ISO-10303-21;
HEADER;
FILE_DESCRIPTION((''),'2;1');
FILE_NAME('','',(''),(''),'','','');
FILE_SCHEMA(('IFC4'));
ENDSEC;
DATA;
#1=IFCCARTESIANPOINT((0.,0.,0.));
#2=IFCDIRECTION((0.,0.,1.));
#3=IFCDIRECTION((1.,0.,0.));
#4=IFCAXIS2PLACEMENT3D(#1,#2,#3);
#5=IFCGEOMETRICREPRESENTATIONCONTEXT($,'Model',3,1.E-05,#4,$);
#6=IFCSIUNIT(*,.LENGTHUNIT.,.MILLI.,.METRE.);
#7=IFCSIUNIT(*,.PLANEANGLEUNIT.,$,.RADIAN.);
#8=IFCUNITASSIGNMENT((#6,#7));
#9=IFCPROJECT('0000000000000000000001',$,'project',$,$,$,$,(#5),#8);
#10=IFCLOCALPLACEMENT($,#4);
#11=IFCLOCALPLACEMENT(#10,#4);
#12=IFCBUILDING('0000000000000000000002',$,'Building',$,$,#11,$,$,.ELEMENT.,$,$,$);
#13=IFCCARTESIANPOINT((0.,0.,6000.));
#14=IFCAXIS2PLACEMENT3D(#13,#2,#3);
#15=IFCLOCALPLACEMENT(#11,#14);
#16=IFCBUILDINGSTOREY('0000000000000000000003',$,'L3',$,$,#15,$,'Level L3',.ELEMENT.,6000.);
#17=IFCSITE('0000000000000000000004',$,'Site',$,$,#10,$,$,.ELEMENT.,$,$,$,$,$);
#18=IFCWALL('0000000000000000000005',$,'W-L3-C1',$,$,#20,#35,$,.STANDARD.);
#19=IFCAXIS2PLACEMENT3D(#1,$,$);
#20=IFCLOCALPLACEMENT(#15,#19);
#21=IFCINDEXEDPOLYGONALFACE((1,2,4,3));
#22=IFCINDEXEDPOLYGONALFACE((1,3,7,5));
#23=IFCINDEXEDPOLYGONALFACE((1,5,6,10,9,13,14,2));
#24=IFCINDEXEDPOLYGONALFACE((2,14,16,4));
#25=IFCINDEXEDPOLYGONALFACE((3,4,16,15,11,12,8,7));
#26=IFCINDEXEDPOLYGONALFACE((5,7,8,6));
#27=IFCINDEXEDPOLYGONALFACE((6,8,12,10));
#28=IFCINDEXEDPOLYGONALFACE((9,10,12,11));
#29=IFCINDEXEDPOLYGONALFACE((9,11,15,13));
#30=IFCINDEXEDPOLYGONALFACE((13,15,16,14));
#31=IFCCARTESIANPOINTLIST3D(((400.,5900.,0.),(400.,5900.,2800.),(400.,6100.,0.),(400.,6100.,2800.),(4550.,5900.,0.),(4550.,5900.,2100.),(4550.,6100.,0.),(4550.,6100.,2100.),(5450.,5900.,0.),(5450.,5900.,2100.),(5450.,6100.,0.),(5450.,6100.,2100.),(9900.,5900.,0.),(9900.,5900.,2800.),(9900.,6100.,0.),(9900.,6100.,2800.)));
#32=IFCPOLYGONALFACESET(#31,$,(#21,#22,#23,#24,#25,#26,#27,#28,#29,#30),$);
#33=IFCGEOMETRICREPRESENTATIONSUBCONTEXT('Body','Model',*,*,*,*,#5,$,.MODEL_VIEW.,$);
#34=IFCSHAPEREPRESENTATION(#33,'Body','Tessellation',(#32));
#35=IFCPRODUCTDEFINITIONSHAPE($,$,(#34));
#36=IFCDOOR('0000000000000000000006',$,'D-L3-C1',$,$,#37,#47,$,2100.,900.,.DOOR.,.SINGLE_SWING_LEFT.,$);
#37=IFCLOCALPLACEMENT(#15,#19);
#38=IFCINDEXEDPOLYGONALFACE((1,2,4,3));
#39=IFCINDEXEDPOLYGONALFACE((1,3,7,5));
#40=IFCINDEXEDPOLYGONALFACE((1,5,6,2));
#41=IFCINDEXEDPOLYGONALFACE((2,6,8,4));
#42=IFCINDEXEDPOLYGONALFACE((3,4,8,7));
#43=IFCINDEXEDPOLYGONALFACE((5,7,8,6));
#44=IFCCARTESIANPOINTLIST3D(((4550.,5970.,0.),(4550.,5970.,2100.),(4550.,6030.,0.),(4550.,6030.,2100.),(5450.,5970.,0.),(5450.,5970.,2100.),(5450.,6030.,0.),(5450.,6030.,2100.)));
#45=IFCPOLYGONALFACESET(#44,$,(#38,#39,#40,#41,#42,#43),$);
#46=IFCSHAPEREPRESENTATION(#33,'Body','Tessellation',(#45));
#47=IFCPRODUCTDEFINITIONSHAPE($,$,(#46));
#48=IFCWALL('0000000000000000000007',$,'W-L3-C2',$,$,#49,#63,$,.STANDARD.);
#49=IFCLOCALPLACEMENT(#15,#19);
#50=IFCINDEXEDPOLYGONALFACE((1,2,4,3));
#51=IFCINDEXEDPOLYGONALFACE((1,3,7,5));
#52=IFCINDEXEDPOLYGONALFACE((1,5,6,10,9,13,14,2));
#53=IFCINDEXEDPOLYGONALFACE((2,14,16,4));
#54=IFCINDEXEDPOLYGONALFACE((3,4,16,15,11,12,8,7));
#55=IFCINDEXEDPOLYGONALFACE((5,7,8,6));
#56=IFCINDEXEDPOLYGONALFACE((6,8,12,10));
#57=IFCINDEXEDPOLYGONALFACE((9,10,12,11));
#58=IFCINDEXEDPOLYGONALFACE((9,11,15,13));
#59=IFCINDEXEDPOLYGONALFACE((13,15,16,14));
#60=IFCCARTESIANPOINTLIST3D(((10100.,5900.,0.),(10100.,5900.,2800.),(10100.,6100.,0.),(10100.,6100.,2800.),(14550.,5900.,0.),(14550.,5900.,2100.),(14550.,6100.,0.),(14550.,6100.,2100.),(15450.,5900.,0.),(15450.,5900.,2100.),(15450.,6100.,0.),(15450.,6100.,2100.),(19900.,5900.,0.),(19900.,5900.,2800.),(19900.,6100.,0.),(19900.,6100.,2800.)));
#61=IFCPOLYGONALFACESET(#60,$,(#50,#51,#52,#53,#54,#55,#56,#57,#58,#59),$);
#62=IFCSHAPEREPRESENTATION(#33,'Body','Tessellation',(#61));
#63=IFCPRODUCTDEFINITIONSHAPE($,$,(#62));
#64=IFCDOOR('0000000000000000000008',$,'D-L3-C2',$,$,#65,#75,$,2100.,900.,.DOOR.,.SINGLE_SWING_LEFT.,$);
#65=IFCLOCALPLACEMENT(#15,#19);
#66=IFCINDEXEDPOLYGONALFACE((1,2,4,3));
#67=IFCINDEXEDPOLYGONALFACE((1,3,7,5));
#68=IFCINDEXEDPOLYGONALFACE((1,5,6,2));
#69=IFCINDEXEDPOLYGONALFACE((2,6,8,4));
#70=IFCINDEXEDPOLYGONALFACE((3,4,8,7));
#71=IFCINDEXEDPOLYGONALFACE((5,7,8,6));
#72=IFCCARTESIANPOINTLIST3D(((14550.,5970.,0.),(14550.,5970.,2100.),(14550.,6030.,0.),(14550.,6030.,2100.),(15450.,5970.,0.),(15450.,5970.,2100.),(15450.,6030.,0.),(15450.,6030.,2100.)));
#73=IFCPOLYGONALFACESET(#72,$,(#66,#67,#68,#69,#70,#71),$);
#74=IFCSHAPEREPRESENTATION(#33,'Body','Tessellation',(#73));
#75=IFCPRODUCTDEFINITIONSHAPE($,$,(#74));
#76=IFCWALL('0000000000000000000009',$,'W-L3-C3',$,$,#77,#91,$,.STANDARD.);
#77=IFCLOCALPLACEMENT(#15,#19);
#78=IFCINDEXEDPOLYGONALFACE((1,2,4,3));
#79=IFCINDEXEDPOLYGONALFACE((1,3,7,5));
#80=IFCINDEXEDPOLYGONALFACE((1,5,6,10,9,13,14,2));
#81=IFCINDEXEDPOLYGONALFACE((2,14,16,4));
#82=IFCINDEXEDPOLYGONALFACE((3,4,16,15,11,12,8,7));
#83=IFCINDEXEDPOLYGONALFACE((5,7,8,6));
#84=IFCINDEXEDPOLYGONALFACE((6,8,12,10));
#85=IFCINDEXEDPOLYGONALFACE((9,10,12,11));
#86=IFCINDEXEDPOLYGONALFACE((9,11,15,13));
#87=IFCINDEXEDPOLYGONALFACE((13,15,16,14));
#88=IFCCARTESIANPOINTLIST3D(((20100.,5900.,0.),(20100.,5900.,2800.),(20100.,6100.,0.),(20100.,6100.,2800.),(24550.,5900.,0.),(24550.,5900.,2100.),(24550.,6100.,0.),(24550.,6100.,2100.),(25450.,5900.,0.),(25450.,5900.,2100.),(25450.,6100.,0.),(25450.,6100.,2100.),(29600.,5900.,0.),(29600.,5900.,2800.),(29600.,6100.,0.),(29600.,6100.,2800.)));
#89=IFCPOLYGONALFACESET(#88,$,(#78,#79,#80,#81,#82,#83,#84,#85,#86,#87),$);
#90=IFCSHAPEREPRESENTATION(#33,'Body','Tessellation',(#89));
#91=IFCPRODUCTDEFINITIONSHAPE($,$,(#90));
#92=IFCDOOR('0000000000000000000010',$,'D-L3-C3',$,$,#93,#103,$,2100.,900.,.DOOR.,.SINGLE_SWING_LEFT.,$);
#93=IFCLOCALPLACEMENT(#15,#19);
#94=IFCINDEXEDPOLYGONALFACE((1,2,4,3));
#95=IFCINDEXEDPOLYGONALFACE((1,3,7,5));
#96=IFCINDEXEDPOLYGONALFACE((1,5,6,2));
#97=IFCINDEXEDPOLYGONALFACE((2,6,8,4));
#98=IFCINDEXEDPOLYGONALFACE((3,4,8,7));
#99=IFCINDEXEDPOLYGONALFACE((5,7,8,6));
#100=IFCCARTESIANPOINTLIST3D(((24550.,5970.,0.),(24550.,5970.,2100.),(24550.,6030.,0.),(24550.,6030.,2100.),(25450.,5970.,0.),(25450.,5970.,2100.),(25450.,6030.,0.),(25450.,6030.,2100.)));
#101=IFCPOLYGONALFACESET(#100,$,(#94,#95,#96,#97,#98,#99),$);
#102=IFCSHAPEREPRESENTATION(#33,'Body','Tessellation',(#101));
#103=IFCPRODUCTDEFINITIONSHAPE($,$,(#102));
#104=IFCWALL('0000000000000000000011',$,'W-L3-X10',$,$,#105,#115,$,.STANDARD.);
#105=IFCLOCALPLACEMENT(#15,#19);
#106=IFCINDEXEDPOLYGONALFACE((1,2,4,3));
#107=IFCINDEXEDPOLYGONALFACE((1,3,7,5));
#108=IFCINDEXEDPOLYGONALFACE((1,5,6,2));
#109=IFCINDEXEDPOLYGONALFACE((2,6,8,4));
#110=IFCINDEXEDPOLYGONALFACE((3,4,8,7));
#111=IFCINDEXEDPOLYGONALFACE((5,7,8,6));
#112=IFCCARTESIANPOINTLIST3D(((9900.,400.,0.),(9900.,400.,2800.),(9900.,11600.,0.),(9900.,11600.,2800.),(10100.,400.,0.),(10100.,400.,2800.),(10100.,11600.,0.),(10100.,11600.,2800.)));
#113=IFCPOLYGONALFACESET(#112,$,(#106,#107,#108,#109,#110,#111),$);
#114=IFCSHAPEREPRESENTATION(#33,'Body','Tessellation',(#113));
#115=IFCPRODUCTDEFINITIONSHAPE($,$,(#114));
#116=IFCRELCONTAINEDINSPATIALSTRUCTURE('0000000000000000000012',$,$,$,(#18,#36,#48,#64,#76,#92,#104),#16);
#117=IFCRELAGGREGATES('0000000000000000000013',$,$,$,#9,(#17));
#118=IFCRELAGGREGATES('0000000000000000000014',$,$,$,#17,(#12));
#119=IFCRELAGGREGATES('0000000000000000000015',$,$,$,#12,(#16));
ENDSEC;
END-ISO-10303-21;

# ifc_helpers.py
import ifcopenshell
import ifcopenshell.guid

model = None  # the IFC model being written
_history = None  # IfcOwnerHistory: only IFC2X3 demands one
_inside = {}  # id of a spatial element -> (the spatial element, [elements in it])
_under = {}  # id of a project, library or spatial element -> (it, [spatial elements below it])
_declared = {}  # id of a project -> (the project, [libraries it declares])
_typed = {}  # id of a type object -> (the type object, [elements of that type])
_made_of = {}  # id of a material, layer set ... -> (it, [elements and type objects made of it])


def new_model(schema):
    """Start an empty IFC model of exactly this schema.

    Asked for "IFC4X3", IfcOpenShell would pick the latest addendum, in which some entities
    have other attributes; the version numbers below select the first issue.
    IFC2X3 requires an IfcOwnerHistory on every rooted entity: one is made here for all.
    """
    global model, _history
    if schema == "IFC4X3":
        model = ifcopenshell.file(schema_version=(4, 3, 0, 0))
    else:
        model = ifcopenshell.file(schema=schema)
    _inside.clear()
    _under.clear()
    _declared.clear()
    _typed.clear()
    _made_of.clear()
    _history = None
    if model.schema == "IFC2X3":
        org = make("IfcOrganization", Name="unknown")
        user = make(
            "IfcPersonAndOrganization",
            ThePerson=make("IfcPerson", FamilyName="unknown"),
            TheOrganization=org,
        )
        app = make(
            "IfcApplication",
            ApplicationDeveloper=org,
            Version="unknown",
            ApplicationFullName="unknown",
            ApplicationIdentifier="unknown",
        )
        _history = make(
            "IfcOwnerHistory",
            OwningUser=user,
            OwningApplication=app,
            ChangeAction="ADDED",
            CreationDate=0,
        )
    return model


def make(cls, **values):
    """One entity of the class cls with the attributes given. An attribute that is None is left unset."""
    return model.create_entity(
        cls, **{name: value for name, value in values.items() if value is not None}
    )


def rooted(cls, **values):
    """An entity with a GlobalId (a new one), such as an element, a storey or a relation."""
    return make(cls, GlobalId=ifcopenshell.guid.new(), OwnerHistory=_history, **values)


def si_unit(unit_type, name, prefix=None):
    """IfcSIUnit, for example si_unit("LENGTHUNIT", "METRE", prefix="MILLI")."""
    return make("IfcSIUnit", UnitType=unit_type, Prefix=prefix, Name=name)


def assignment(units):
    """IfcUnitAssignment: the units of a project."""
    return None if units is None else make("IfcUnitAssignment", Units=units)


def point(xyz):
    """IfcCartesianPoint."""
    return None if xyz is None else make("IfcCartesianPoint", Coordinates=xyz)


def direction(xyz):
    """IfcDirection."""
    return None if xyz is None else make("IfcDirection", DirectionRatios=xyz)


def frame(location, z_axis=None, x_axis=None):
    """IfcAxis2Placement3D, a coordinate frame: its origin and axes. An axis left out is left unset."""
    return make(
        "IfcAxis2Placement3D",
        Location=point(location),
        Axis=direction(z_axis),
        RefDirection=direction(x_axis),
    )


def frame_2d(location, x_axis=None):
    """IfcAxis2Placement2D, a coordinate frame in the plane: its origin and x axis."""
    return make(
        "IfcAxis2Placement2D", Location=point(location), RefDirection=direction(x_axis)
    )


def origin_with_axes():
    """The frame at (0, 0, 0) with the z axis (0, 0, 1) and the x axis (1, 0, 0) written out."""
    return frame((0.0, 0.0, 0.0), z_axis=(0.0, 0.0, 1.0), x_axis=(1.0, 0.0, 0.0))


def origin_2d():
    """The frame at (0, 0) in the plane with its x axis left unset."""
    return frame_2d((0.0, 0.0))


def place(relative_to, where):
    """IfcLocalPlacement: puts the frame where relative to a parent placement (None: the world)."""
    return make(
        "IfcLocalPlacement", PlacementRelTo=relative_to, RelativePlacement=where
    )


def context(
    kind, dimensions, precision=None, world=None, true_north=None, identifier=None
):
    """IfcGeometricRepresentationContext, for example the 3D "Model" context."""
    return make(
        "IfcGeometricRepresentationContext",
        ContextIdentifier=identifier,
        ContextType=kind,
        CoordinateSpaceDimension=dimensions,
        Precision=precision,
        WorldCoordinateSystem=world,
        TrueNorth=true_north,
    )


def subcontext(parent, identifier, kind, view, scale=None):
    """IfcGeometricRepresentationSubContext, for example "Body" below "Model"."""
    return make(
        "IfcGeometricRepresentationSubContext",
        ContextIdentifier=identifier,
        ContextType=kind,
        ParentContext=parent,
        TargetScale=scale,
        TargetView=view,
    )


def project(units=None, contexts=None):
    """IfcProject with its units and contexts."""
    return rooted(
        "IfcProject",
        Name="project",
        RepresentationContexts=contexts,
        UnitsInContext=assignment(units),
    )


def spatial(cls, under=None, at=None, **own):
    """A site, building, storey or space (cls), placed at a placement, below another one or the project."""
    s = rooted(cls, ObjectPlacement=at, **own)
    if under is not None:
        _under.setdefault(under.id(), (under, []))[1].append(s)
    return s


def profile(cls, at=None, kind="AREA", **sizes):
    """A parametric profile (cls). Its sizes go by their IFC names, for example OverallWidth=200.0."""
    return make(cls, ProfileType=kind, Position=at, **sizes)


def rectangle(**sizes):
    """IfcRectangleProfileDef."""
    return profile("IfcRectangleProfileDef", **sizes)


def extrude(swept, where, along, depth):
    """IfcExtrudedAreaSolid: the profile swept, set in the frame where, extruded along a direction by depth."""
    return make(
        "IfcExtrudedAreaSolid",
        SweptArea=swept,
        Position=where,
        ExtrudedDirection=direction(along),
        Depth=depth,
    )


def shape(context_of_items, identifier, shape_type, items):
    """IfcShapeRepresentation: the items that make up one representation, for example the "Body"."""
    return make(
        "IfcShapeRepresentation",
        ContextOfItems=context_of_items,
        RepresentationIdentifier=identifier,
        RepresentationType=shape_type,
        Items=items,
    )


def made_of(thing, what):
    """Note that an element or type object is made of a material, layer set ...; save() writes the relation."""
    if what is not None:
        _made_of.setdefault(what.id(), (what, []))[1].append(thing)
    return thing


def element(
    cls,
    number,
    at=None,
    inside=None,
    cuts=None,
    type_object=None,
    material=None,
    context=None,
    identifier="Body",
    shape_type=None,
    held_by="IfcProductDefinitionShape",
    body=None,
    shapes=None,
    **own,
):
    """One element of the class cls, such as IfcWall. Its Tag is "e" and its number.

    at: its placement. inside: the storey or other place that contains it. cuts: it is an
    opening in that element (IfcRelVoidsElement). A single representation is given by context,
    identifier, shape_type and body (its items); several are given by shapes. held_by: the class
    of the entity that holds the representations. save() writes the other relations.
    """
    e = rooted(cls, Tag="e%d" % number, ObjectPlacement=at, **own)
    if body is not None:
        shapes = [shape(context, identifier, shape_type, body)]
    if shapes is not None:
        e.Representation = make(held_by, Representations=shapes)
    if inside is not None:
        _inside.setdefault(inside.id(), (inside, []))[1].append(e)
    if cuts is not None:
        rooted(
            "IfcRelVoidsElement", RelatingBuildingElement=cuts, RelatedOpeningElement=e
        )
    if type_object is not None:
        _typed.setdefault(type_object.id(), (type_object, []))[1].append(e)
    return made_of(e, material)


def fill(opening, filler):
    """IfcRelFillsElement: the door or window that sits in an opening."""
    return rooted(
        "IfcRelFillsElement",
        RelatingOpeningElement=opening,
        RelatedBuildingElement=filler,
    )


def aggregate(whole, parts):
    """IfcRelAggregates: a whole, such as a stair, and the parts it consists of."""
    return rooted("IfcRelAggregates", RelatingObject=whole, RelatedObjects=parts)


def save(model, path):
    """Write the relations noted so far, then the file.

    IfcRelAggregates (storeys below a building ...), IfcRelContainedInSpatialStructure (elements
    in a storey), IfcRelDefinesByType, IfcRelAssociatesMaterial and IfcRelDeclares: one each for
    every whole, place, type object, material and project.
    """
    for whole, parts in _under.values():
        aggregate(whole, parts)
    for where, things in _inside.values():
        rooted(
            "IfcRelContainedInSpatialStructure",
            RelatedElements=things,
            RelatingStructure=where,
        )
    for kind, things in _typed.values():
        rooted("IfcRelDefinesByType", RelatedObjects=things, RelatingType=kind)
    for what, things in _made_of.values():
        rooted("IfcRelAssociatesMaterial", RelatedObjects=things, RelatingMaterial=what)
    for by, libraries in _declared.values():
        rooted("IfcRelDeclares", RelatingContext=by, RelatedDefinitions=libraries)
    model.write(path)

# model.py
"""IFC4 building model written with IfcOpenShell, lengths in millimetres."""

from ifc_helpers import new_model, si_unit, frame, origin_with_axes, origin_2d, place, context, subcontext, project, spatial, rectangle, extrude, element, fill, save


model = new_model("IFC4")

# Units and contexts
model_context = context("Model", 3, precision=1e-05, world=origin_with_axes())
body_context = subcontext(model_context, "Body", "Model", "MODEL_VIEW")
ifc_project = project(units=[si_unit("LENGTHUNIT", "METRE", prefix="MILLI"), si_unit("PLANEANGLEUNIT", "RADIAN")], contexts=[model_context])

# Site, building, storey
site_placement = place(None, origin_with_axes())
site = spatial("IfcSite", under=ifc_project, at=site_placement, Name="Site", CompositionType="ELEMENT")
building_placement = place(site_placement, origin_with_axes())
building = spatial("IfcBuilding", under=site, at=building_placement, Name="Building", CompositionType="ELEMENT")
storey_placement = place(building_placement, frame((0.0, 0.0, 6000.0), z_axis=(0.0, 0.0, 1.0), x_axis=(1.0, 0.0, 0.0)))
storey = spatial("IfcBuildingStorey", under=building, at=storey_placement, Name="L3", LongName="Level L3", CompositionType="ELEMENT", Elevation=6000.0)

# Walls, openings, doors
wall_1_placement = place(storey_placement, frame((5150.0, 6000.0, 0.0), z_axis=(0.0, 0.0, 1.0), x_axis=(1.0, 0.0, 0.0)))
wall_1 = element("IfcWall", 1, at=wall_1_placement, inside=storey, Name="W-L3-C1", PredefinedType="STANDARD", context=body_context, shape_type="SweptSolid", body=[
    extrude(rectangle(XDim=9500.0, YDim=200.0, at=origin_2d()), origin_with_axes(), (0.0, 0.0, 1.0), 2800.0),
])
opening_1_placement = place(wall_1_placement, frame((-150.0, 0.0, 0.0), z_axis=(0.0, 0.0, 1.0), x_axis=(1.0, 0.0, 0.0)))
opening_1 = element("IfcOpeningElement", 2, at=opening_1_placement, cuts=wall_1, PredefinedType="OPENING", context=body_context, shape_type="SweptSolid", body=[
    extrude(rectangle(XDim=900.0, YDim=300.0, at=origin_2d()), origin_with_axes(), (0.0, 0.0, 1.0), 2100.0),
])
door_1_placement = place(wall_1_placement, frame((-150.0, 0.0, 0.0), z_axis=(0.0, 0.0, 1.0), x_axis=(1.0, 0.0, 0.0)))
door_1 = element("IfcDoor", 3, at=door_1_placement, inside=storey, Name="D-L3-C1", OperationType="SINGLE_SWING_LEFT", OverallHeight=2100.0, OverallWidth=900.0, PredefinedType="DOOR", context=body_context, shape_type="SweptSolid", body=[
    extrude(rectangle(XDim=900.0, YDim=60.0, at=origin_2d()), origin_with_axes(), (0.0, 0.0, 1.0), 2100.0),
])
fill(opening_1, door_1)
wall_2_placement = place(storey_placement, frame((15000.0, 6000.0, 0.0), z_axis=(0.0, 0.0, 1.0), x_axis=(1.0, 0.0, 0.0)))
wall_2 = element("IfcWall", 4, at=wall_2_placement, inside=storey, Name="W-L3-C2", PredefinedType="STANDARD", context=body_context, shape_type="SweptSolid", body=[
    extrude(rectangle(XDim=9800.0, YDim=200.0, at=origin_2d()), origin_with_axes(), (0.0, 0.0, 1.0), 2800.0),
])
opening_2_placement = place(wall_2_placement, origin_with_axes())
opening_2 = element("IfcOpeningElement", 5, at=opening_2_placement, cuts=wall_2, PredefinedType="OPENING", context=body_context, shape_type="SweptSolid", body=[
    extrude(rectangle(XDim=900.0, YDim=300.0, at=origin_2d()), origin_with_axes(), (0.0, 0.0, 1.0), 2100.0),
])
door_2_placement = place(wall_2_placement, origin_with_axes())
door_2 = element("IfcDoor", 6, at=door_2_placement, inside=storey, Name="D-L3-C2", OperationType="SINGLE_SWING_LEFT", OverallHeight=2100.0, OverallWidth=900.0, PredefinedType="DOOR", context=body_context, shape_type="SweptSolid", body=[
    extrude(rectangle(XDim=900.0, YDim=60.0, at=origin_2d()), origin_with_axes(), (0.0, 0.0, 1.0), 2100.0),
])
fill(opening_2, door_2)
wall_3_placement = place(storey_placement, frame((24850.0, 6000.0, 0.0), z_axis=(0.0, 0.0, 1.0), x_axis=(1.0, 0.0, 0.0)))
wall_3 = element("IfcWall", 7, at=wall_3_placement, inside=storey, Name="W-L3-C3", PredefinedType="STANDARD", context=body_context, shape_type="SweptSolid", body=[
    extrude(rectangle(XDim=9500.0, YDim=200.0, at=origin_2d()), origin_with_axes(), (0.0, 0.0, 1.0), 2800.0),
])
opening_3_placement = place(wall_3_placement, frame((150.0, 0.0, 0.0), z_axis=(0.0, 0.0, 1.0), x_axis=(1.0, 0.0, 0.0)))
opening_3 = element("IfcOpeningElement", 8, at=opening_3_placement, cuts=wall_3, PredefinedType="OPENING", context=body_context, shape_type="SweptSolid", body=[
    extrude(rectangle(XDim=900.0, YDim=300.0, at=origin_2d()), origin_with_axes(), (0.0, 0.0, 1.0), 2100.0),
])
door_3_placement = place(wall_3_placement, frame((150.0, 0.0, 0.0), z_axis=(0.0, 0.0, 1.0), x_axis=(1.0, 0.0, 0.0)))
door_3 = element("IfcDoor", 9, at=door_3_placement, inside=storey, Name="D-L3-C3", OperationType="SINGLE_SWING_LEFT", OverallHeight=2100.0, OverallWidth=900.0, PredefinedType="DOOR", context=body_context, shape_type="SweptSolid", body=[
    extrude(rectangle(XDim=900.0, YDim=60.0, at=origin_2d()), origin_with_axes(), (0.0, 0.0, 1.0), 2100.0),
])
fill(opening_3, door_3)

# Wall
wall_4_placement = place(storey_placement, frame((10000.0, 6000.0, 0.0), z_axis=(0.0, 0.0, 1.0), x_axis=(1.0, 0.0, 0.0)))
element("IfcWall", 10, at=wall_4_placement, inside=storey, Name="W-L3-X10", PredefinedType="STANDARD", context=body_context, shape_type="SweptSolid", body=[
    extrude(rectangle(XDim=200.0, YDim=11200.0, at=origin_2d()), origin_with_axes(), (0.0, 0.0, 1.0), 2800.0),
])

save(model, "model.ifc")
